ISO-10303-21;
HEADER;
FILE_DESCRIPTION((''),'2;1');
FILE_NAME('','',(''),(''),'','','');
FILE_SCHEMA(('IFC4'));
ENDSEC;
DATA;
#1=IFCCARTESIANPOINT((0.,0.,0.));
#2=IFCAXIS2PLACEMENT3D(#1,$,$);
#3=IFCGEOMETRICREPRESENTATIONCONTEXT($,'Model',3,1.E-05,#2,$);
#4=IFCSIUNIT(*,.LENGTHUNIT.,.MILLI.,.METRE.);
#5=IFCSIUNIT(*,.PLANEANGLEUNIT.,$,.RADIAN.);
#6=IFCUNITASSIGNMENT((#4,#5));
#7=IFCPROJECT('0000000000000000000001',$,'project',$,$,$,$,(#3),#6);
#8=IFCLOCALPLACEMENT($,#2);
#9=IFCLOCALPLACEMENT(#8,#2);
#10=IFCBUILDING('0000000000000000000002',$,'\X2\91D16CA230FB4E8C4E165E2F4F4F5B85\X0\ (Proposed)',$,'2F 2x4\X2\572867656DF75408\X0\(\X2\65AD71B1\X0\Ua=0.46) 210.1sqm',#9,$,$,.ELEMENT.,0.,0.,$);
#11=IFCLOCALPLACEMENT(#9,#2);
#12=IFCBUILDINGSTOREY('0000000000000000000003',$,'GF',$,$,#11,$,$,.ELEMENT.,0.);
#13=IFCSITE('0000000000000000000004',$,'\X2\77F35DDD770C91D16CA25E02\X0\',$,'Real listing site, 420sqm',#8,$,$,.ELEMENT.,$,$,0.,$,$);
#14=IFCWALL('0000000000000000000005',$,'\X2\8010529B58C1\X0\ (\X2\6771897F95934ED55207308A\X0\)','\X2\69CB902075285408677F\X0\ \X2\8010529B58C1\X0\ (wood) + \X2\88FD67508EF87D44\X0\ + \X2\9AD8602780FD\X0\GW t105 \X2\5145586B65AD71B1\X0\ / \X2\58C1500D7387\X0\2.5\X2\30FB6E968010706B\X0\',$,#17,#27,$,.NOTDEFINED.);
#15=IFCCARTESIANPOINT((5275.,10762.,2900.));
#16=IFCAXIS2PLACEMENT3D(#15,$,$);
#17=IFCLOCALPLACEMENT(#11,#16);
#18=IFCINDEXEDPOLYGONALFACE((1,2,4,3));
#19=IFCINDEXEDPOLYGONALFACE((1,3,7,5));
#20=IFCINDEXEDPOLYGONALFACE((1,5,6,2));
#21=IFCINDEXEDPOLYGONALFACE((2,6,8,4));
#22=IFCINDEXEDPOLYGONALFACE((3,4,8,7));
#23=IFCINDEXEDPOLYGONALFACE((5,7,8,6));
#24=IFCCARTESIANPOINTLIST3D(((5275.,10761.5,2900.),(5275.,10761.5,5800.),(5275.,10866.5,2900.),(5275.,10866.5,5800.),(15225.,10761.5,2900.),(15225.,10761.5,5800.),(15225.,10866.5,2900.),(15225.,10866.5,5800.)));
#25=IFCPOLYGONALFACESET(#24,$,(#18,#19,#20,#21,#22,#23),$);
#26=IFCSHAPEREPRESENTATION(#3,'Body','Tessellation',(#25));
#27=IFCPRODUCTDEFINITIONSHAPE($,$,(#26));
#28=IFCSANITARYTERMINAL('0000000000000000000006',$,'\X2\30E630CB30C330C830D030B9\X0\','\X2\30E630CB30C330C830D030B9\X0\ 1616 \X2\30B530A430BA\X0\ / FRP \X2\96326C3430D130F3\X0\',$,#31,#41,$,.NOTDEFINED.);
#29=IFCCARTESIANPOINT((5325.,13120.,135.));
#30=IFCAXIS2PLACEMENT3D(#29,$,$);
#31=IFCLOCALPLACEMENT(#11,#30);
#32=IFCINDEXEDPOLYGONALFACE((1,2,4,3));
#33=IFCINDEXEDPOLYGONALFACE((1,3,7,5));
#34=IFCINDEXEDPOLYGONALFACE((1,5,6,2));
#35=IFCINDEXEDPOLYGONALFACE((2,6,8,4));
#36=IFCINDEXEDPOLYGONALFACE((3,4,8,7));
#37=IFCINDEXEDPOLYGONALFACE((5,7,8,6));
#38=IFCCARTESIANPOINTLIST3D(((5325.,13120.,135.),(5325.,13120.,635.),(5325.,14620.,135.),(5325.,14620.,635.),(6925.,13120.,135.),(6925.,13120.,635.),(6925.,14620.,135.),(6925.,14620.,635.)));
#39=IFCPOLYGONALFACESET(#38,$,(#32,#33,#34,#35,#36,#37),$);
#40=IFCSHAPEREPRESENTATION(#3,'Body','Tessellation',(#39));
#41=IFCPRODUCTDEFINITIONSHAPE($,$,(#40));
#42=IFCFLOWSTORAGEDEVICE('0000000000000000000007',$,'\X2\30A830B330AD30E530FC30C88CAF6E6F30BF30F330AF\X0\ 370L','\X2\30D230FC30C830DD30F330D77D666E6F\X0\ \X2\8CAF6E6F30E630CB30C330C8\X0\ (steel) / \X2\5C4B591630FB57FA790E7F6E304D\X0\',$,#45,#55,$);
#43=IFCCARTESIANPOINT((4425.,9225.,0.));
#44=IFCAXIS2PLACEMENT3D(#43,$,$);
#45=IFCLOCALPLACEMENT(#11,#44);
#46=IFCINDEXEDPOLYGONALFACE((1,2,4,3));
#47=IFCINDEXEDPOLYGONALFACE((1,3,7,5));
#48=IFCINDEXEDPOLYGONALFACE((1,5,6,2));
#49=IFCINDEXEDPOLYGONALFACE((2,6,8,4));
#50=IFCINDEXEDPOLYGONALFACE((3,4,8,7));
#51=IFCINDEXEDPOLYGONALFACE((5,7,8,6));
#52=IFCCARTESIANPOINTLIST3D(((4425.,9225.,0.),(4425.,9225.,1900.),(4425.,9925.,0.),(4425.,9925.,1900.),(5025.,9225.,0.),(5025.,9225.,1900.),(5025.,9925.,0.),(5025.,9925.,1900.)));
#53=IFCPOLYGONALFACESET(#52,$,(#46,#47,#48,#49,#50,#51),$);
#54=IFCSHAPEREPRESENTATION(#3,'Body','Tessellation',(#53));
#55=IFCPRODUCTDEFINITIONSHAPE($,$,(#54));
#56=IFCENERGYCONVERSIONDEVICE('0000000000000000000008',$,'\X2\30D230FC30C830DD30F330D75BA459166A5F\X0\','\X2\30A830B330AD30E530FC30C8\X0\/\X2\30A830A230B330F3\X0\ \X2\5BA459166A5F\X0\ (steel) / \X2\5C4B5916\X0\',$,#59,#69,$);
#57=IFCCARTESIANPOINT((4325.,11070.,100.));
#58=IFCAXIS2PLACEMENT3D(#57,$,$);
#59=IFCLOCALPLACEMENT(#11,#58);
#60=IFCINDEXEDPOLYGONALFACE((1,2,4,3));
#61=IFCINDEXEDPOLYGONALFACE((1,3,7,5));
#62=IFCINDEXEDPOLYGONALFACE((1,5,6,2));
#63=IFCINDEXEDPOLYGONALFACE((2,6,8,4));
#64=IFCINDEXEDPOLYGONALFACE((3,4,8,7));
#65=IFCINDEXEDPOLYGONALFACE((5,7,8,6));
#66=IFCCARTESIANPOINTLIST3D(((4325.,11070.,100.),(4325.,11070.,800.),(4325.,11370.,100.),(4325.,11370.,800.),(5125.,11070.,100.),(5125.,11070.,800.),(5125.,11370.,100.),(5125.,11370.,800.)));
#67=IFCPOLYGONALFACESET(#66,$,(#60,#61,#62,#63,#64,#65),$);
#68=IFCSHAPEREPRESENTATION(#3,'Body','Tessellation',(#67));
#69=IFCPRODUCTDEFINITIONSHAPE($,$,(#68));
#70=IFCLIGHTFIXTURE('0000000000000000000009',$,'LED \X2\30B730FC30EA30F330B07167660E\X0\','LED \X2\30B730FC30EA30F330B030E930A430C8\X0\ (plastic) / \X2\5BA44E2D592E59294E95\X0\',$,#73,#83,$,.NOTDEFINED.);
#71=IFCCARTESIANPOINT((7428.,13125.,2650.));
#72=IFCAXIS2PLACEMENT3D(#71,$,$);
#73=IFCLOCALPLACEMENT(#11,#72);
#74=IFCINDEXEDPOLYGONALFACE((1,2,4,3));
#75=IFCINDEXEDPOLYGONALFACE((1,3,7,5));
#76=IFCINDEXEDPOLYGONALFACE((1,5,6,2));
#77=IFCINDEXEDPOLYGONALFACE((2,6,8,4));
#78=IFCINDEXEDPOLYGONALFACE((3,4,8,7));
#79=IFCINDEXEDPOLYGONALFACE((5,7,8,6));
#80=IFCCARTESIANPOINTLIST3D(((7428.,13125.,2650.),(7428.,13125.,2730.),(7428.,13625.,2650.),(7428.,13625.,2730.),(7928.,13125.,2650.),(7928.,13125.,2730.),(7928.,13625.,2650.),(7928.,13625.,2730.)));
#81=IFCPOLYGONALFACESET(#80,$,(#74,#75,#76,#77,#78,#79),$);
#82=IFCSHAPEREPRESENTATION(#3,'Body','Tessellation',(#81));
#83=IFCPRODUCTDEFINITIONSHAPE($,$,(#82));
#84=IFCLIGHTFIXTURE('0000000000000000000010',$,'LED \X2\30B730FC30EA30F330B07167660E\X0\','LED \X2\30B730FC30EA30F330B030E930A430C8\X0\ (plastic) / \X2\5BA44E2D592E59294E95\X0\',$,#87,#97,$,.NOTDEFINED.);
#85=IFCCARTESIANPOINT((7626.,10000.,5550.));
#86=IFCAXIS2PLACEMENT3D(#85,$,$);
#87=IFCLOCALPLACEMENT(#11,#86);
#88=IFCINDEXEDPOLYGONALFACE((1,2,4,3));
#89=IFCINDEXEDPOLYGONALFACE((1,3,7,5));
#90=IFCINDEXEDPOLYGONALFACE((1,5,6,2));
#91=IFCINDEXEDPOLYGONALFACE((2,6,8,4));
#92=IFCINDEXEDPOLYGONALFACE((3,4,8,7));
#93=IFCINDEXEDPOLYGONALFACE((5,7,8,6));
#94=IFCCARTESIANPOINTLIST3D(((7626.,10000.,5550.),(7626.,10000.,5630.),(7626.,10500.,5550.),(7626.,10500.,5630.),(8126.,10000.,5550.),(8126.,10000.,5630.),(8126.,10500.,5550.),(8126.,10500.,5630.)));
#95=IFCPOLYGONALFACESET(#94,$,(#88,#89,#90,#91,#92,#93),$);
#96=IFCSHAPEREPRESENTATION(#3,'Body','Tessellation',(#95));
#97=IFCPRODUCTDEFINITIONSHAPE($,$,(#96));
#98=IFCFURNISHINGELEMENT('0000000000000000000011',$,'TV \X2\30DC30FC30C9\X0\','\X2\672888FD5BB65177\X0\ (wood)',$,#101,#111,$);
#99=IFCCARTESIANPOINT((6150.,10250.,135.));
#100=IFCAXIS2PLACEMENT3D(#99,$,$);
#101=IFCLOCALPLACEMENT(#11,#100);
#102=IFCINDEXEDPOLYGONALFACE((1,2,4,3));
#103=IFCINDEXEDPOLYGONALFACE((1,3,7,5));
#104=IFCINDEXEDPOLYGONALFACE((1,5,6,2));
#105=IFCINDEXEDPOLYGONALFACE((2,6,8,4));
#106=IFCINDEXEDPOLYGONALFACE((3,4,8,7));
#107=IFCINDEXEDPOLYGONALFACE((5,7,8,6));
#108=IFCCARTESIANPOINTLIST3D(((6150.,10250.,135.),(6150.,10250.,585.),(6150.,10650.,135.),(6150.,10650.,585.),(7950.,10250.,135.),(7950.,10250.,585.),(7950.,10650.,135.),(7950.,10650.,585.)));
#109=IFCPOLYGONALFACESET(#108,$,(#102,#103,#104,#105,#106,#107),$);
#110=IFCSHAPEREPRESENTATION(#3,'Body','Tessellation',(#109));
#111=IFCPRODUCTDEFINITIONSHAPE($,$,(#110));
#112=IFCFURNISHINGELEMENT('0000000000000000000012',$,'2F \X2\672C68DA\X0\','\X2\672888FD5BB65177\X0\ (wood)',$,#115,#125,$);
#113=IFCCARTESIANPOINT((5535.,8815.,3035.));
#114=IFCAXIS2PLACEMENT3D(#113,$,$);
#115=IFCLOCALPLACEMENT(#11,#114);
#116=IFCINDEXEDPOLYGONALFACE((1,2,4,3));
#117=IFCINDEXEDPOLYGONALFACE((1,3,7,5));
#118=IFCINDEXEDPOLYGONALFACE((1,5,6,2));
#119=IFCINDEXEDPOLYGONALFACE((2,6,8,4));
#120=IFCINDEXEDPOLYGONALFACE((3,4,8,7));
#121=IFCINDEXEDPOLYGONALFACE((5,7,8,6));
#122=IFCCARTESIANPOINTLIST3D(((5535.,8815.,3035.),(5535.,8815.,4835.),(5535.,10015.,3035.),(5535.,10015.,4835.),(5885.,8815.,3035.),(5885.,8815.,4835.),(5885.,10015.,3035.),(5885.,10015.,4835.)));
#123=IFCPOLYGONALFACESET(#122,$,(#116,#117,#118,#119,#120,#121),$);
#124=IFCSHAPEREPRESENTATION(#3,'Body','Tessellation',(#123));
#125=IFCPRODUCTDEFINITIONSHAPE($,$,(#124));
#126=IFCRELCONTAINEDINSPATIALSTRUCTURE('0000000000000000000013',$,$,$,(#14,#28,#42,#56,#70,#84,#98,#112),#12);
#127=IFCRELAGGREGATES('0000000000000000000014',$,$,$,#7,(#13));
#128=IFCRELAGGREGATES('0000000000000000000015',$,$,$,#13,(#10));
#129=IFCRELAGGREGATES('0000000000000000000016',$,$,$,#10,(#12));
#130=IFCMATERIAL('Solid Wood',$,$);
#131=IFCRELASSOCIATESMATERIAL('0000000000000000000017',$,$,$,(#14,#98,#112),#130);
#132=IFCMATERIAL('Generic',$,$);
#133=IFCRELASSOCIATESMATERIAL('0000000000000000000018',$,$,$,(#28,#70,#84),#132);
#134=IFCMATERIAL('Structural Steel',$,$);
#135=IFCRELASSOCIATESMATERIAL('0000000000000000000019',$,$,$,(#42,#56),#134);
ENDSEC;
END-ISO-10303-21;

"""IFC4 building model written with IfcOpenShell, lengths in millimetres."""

from ifc_helpers import new_model, si_unit, frame, frame_2d, origin, place, context, project, spatial, rectangle, extrude, material, element, save


model = new_model("IFC4")

# Units and contexts
model_context = context("Model", 3, precision=1e-05, world=origin())
ifc_project = project(units=[si_unit("LENGTHUNIT", "METRE", prefix="MILLI"), si_unit("PLANEANGLEUNIT", "RADIAN")], contexts=[model_context])

# Site, building, storey
site_placement = place(None, origin())
site = spatial("IfcSite", under=ifc_project, at=site_placement, Name="石川県金沢市", ObjectType="Real listing site, 420sqm", CompositionType="ELEMENT", RefElevation=0.0)
building_placement = place(site_placement, origin())
building = spatial("IfcBuilding", under=site, at=building_placement, Name="金沢・二世帯住宅 (Proposed)", ObjectType="2F 2x4在来混合(断熱Ua=0.46) 210.1sqm", CompositionType="ELEMENT", ElevationOfRefHeight=0.0, ElevationOfTerrain=0.0)
storey_placement = place(building_placement, origin())
storey = spatial("IfcBuildingStorey", under=building, at=storey_placement, Name="GF", CompositionType="ELEMENT", Elevation=0.0)

# Shared definitions
ifc_material_1 = material(Name="Solid Wood")

# Wall
wall_1_placement = place(storey_placement, frame((5275.0, 10762.0, 2900.0)))
element("IfcWall", 1, at=wall_1_placement, inside=storey, material=ifc_material_1, Name="耐力壁 (東西間仕切り)", Description="構造用合板 耐力壁 (wood) + 製材軸組 + 高性能GW t105 充填断熱 / 壁倍率2.5・準耐火", PredefinedType="NOTDEFINED", context=model_context, shape_type="SweptSolid", body=[
    extrude(rectangle(XDim=9950.0, YDim=105.0, at=frame_2d((4975.0, 52.0))), frame((5275.0, 10762.0, 2900.0)), (0.0, 0.0, 1.0), 2900.0),
])

# Sanitary terminal
ifc_material_2 = material(Name="Generic")
sanitary_terminal_placement = place(storey_placement, frame((5325.0, 13120.0, 135.0)))
element("IfcSanitaryTerminal", 2, at=sanitary_terminal_placement, inside=storey, material=ifc_material_2, Name="ユニットバス", Description="ユニットバス 1616 サイズ / FRP 防水パン", PredefinedType="NOTDEFINED", context=model_context, shape_type="SweptSolid", body=[
    extrude(rectangle(XDim=1600.0, YDim=1500.0, at=frame_2d((800.0, 750.0))), frame((5325.0, 13120.0, 135.0)), (0.0, 0.0, 1.0), 500.0),
])

# Flow storage device
ifc_material_3 = material(Name="Structural Steel")
flow_storage_device_placement = place(storey_placement, frame((4425.0, 9225.0, 0.0)))
element("IfcFlowStorageDevice", 3, at=flow_storage_device_placement, inside=storey, material=ifc_material_3, Name="エコキュート貯湯タンク 370L", Description="ヒートポンプ給湯 貯湯ユニット (steel) / 屋外・基礎置き", context=model_context, shape_type="SweptSolid", body=[
    extrude(rectangle(XDim=600.0, YDim=700.0, at=frame_2d((300.0, 350.0))), frame((4425.0, 9225.0, 0.0)), (0.0, 0.0, 1.0), 1900.0),
])

# Energy conversion device
energy_conversion_device_placement = place(storey_placement, frame((4325.0, 11070.0, 100.0)))
element("IfcEnergyConversionDevice", 4, at=energy_conversion_device_placement, inside=storey, material=ifc_material_3, Name="ヒートポンプ室外機", Description="エコキュート/エアコン 室外機 (steel) / 屋外", context=model_context, shape_type="SweptSolid", body=[
    extrude(rectangle(XDim=800.0, YDim=300.0, at=frame_2d((400.0, 150.0))), frame((4325.0, 11070.0, 100.0)), (0.0, 0.0, 1.0), 700.0),
])

# Light fixtures
light_fixture_1_placement = place(storey_placement, frame((7428.0, 13125.0, 2650.0)))
element("IfcLightFixture", 5, at=light_fixture_1_placement, inside=storey, material=ifc_material_2, Name="LED シーリング照明", Description="LED シーリングライト (plastic) / 室中央天井", PredefinedType="NOTDEFINED", context=model_context, shape_type="SweptSolid", body=[
    extrude(rectangle(XDim=500.0, YDim=500.0, at=frame_2d((250.0, 250.0))), frame((7428.0, 13125.0, 2650.0)), (0.0, 0.0, 1.0), 80.0),
])
light_fixture_2_placement = place(storey_placement, frame((7626.0, 10000.0, 5550.0)))
element("IfcLightFixture", 6, at=light_fixture_2_placement, inside=storey, material=ifc_material_2, Name="LED シーリング照明", Description="LED シーリングライト (plastic) / 室中央天井", PredefinedType="NOTDEFINED", context=model_context, shape_type="SweptSolid", body=[
    extrude(rectangle(XDim=500.0, YDim=500.0, at=frame_2d((250.0, 250.0))), frame((7626.0, 10000.0, 5550.0)), (0.0, 0.0, 1.0), 80.0),
])

# Furnishing elements
furnishing_1_placement = place(storey_placement, frame((6150.0, 10250.0, 135.0)))
element("IfcFurnishingElement", 7, at=furnishing_1_placement, inside=storey, material=ifc_material_1, Name="TV ボード", Description="木製家具 (wood)", context=model_context, shape_type="SweptSolid", body=[
    extrude(rectangle(XDim=1800.0, YDim=400.0, at=frame_2d((900.0, 200.0))), frame((6150.0, 10250.0, 135.0)), (0.0, 0.0, 1.0), 450.0),
])
furnishing_2_placement = place(storey_placement, frame((5535.0, 8815.0, 3035.0)))
element("IfcFurnishingElement", 8, at=furnishing_2_placement, inside=storey, material=ifc_material_1, Name="2F 本棚", Description="木製家具 (wood)", context=model_context, shape_type="SweptSolid", body=[
    extrude(rectangle(XDim=350.0, YDim=1200.0, at=frame_2d((175.0, 600.0))), frame((5535.0, 8815.0, 3035.0)), (0.0, 0.0, 1.0), 1800.0),
])

save(model, "model.ifc")
